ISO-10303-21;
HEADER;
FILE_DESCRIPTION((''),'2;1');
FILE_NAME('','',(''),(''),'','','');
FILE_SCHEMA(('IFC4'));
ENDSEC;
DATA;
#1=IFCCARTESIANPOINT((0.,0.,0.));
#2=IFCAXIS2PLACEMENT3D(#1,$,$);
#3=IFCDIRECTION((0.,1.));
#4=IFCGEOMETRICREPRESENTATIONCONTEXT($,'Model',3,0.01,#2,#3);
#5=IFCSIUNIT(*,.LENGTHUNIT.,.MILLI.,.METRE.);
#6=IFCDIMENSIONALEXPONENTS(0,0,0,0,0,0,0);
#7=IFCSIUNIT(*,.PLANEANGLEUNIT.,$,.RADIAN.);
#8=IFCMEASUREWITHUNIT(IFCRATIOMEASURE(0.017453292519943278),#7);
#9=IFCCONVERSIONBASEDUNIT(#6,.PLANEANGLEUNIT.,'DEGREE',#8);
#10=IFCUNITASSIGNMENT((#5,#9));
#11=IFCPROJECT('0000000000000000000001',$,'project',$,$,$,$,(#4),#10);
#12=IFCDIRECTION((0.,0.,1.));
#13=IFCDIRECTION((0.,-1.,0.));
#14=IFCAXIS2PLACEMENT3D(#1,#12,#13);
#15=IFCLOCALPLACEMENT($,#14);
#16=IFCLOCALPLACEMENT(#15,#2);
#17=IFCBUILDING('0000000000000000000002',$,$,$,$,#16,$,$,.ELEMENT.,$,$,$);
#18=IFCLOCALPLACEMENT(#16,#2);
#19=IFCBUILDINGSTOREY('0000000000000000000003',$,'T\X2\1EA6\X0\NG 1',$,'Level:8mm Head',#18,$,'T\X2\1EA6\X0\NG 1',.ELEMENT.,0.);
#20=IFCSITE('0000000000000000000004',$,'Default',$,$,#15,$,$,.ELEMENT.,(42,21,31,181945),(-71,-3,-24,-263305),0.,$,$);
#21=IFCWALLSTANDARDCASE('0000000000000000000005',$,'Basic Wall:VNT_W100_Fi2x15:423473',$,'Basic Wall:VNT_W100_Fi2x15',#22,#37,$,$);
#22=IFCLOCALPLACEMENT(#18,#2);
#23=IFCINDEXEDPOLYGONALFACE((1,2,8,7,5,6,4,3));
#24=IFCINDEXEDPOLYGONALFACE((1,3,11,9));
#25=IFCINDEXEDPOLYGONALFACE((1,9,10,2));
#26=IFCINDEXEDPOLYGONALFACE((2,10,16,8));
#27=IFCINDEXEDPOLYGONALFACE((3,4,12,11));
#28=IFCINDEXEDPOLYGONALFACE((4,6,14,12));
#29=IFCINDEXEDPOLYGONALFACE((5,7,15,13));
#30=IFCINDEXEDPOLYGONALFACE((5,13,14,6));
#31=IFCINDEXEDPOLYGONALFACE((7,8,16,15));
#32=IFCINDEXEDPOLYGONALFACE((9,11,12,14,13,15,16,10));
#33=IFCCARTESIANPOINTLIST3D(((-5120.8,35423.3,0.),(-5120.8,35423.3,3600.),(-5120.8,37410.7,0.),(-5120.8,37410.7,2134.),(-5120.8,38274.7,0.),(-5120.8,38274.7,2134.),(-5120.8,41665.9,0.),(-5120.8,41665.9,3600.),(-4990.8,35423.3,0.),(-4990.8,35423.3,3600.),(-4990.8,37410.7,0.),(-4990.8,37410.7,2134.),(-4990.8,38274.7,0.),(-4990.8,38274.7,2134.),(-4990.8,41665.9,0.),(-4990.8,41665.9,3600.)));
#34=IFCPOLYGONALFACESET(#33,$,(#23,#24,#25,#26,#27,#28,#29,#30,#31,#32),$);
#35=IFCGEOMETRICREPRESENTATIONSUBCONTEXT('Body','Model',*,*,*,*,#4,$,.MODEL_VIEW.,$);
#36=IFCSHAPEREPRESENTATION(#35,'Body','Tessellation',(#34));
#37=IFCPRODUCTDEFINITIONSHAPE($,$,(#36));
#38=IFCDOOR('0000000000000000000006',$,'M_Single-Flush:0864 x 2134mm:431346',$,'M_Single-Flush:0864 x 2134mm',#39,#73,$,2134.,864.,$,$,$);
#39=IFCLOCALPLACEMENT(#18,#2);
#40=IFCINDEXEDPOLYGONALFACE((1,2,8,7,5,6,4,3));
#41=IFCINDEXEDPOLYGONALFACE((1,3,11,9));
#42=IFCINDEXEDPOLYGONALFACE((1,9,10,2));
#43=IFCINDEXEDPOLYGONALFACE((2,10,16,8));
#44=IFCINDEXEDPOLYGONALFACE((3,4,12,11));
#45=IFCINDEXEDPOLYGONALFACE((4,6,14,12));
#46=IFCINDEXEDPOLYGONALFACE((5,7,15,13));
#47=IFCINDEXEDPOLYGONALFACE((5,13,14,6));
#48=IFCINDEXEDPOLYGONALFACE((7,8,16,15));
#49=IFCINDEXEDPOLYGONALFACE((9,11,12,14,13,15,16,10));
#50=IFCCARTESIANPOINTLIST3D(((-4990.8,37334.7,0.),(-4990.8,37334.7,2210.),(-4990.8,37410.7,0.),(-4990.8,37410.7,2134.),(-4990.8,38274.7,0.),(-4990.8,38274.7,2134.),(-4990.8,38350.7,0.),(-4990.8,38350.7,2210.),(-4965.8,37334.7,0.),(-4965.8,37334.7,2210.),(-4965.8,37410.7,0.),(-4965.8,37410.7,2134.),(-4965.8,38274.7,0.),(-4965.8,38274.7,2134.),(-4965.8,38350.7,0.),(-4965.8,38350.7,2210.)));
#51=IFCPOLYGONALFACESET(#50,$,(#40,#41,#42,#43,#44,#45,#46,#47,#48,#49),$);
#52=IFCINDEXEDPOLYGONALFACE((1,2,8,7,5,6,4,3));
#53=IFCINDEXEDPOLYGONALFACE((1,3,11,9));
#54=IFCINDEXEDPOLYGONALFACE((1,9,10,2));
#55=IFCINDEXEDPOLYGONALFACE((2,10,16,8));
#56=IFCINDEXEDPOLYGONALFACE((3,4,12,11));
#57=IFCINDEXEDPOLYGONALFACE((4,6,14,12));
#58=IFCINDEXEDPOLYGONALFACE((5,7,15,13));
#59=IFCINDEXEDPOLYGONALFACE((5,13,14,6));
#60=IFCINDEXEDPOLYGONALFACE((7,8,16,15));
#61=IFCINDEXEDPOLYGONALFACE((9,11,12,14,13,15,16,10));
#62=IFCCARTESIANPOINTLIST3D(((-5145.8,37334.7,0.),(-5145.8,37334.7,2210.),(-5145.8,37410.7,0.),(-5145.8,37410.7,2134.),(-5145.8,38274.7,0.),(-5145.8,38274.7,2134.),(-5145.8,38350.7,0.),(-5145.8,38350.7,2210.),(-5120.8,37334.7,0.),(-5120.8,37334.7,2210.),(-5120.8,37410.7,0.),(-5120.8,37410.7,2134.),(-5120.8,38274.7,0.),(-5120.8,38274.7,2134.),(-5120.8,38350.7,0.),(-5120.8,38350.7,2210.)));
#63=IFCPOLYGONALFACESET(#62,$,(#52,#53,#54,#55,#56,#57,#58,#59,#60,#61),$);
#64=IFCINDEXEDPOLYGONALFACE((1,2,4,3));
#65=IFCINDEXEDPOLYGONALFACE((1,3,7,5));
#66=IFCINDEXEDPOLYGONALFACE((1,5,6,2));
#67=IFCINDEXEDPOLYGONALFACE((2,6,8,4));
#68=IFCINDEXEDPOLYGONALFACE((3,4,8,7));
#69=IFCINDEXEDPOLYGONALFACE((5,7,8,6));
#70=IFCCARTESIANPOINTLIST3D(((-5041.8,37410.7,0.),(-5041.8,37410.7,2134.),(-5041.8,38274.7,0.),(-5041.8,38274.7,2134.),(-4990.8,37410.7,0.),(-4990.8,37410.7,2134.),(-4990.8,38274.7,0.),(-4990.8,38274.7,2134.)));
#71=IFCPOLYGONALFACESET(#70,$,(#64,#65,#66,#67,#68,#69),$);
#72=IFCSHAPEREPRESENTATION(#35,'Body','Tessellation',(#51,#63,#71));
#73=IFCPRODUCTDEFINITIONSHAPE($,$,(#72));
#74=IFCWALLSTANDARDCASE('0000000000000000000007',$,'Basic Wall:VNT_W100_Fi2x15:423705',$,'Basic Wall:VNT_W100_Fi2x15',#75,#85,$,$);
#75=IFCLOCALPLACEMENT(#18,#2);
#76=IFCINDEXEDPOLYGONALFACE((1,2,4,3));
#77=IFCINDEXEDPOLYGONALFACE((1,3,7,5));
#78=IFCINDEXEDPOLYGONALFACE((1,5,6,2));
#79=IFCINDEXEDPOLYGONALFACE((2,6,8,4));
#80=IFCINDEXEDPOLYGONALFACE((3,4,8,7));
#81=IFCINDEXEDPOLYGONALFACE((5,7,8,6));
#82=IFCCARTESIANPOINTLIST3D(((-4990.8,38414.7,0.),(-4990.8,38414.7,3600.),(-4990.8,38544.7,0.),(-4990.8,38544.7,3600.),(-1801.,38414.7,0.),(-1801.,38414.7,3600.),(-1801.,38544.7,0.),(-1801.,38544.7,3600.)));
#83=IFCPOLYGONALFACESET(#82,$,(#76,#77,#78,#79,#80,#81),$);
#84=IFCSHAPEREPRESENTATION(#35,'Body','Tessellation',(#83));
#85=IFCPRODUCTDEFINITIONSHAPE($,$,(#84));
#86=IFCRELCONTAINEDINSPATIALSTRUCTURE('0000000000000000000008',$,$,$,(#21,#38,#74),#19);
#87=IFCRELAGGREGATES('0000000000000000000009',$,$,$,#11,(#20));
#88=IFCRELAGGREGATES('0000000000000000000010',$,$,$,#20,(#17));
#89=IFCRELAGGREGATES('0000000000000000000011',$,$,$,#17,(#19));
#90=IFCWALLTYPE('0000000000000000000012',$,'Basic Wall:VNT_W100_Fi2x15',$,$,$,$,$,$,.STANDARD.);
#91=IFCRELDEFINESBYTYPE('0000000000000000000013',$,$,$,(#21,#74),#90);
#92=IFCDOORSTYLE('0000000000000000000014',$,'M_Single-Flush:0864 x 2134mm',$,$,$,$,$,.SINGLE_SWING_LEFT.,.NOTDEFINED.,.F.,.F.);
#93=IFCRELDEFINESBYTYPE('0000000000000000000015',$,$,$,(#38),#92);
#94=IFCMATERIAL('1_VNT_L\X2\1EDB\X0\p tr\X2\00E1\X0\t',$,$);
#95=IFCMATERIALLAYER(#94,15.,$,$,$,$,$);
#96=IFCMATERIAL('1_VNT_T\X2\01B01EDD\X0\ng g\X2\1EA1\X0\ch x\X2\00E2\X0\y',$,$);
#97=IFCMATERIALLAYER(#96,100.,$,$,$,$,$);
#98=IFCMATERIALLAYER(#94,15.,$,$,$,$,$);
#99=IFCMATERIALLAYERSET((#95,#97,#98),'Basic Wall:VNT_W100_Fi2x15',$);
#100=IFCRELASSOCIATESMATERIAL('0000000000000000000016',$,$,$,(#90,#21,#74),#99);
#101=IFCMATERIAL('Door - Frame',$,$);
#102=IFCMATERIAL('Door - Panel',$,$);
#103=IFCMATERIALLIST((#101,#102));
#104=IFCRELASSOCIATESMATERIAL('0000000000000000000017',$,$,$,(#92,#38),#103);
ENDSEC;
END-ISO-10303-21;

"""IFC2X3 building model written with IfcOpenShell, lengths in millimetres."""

from ifc_helpers import new_model, entity, si_unit, converted_unit, direction, frame, frame_2d, origin, place, context, subcontext, project, spatial, polyline, rectangle, outline, extrude, source, transform, mapped, material, material_list, layer, layer_set, layer_usage, type_object, type_shapes, element, fill, save


model = new_model("IFC2X3")

# Units and contexts
model_context = context("Model", 3, precision=0.01, world=origin(), true_north=direction((0.0, 1.0)))
body_context = subcontext(model_context, "Body", "Model", "MODEL_VIEW")
ifc_project = project(units=[si_unit("LENGTHUNIT", "METRE", prefix="MILLI"), converted_unit("PLANEANGLEUNIT", "DEGREE", entity("IfcRatioMeasure", 0.017453292519943278), si_unit("PLANEANGLEUNIT", "RADIAN"), dimensions=[0, 0, 0, 0, 0, 0, 0])], contexts=[model_context])

# Site, building, storey
site_placement = place(None, frame((0.0, 0.0, 0.0), z_axis=(0.0, 0.0, 1.0), x_axis=(0.0, -1.0, 0.0)))
site = spatial("IfcSite", under=ifc_project, at=site_placement, Name="Default", CompositionType="ELEMENT", RefLatitude=(42, 21, 31, 181945), RefLongitude=(-71, -3, -24, -263305), RefElevation=0.0)
building_placement = place(site_placement, origin())
building = spatial("IfcBuilding", under=site, at=building_placement, CompositionType="ELEMENT")
storey_placement = place(building_placement, origin())
storey = spatial("IfcBuildingStorey", under=building, at=storey_placement, Name="TẦNG 1", ObjectType="Level:8mm Head", LongName="TẦNG 1", CompositionType="ELEMENT", Elevation=0.0)

# Shared definitions
ifc_material_1 = material(Name="1_VNT_Lớp trát")
ifc_material_2 = material(Name="1_VNT_Tường gạch xây")

# Shared definitions
ifc_material_3 = material(Name="Door - Frame")
ifc_material_4 = material(Name="Door - Panel")
ifc_material_list = material_list([ifc_material_3, ifc_material_4])

# Wall, opening, door
ifc_layer_1 = layer(ifc_material_1, 15.0)
ifc_layer_2 = layer(ifc_material_2, 100.0)
ifc_layer_3 = layer(ifc_material_1, 15.0)
ifc_layer_set_1 = layer_set([ifc_layer_1, ifc_layer_2, ifc_layer_3], Name="Basic Wall:VNT_W100_Fi2x15")
ifc_layer_usage_1 = layer_usage(ifc_layer_set_1, "AXIS2", "NEGATIVE", 65.0)
wall_type_1 = type_object("IfcWallType", Name="Basic Wall:VNT_W100_Fi2x15", PredefinedType="STANDARD", material=ifc_layer_set_1)
wall_1_placement = place(storey_placement, frame((-5055.8, 35423.3, 0.0), z_axis=(0.0, 0.0, 1.0), x_axis=(0.0, 1.0, 0.0)))
wall_1 = element("IfcWallStandardCase", 1, at=wall_1_placement, inside=storey, type_object=wall_type_1, material=ifc_layer_usage_1, Name="Basic Wall:VNT_W100_Fi2x15:423473", ObjectType="Basic Wall:VNT_W100_Fi2x15", context=body_context, shape_type="SweptSolid", body=[
    extrude(rectangle(XDim=6242.6, YDim=130.0, at=frame_2d((3121.3, 0.0), x_axis=(-1.0, 0.0))), origin(), (0.0, 0.0, 1.0), 3600.0),
])
opening_1_placement = place(wall_1_placement, frame((2851.4, 65.0, 0.0)))
opening_1 = element("IfcOpeningElement", 2, at=opening_1_placement, cuts=wall_1, ObjectType="Opening", context=body_context, shape_type="SweptSolid", body=[
    extrude(rectangle(XDim=864.0, YDim=2134.0, at=frame_2d((1067.0, 432.0), x_axis=(0.0, -1.0))), frame((0.0, 0.0, 0.0), z_axis=(0.0, -1.0, 0.0), x_axis=(0.0, 0.0, 1.0)), (0.0, 0.0, 1.0), 130.0),
])
door_style_1 = type_object("IfcDoorStyle", Name="M_Single-Flush:0864 x 2134mm", ConstructionType="NOTDEFINED", OperationType="SINGLE_SWING_LEFT", ParameterTakesPrecedence=False, Sizeable=False, material=ifc_material_list)
shared_shape_1 = source(origin(), body_context, "Body", "SweptSolid", [
    extrude(outline(polyline([(-508.0, -1124.0), (508.0, -1124.0), (508.0, 1086.0), (432.0, 1086.0), (432.0, -1048.0), (-432.0, -1048.0), (-432.0, 1086.0), (-508.0, 1086.0), (-508.0, -1124.0)])), frame((432.0, 155.0, 1086.0), z_axis=(0.0, -1.0, 0.0), x_axis=(-1.0, 0.0, 0.0)), (0.0, 0.0, 1.0), 25.0),
    extrude(outline(polyline([(-1124.0, -508.0), (1086.0, -508.0), (1086.0, -432.0), (-1048.0, -432.0), (-1048.0, 432.0), (1086.0, 432.0), (1086.0, 508.0), (-1124.0, 508.0), (-1124.0, -508.0)])), frame((432.0, 0.0, 1086.0), z_axis=(0.0, -1.0, 0.0), x_axis=(0.0, 0.0, -1.0)), (0.0, 0.0, 1.0), 25.0),
    extrude(rectangle(XDim=864.0, YDim=51.0, at=frame_2d((0.0, 0.0), x_axis=(1.0, 0.0))), frame((432.0, 104.5, 0.0)), (0.0, 0.0, 1.0), 2134.0),
])
type_shapes(door_style_1, [shared_shape_1])
door_1_placement = place(opening_1_placement, frame((0.0, 0.0, 0.0), z_axis=(0.0, 0.0, 1.0), x_axis=(-1.0, 0.0, 0.0)))
door_1 = element("IfcDoor", 3, at=door_1_placement, inside=storey, type_object=door_style_1, material=ifc_material_list, Name="M_Single-Flush:0864 x 2134mm:431346", ObjectType="M_Single-Flush:0864 x 2134mm", OverallHeight=2134.0, OverallWidth=864.0, context=body_context, shape_type="MappedRepresentation", body=[
    mapped(shared_shape_1, transform((0.0, 0.0, 0.0), scale=1.0)),
])
fill(opening_1, door_1)

# Wall
wall_2_placement = place(storey_placement, frame((-4990.8, 38479.7, 0.0)))
element("IfcWallStandardCase", 4, at=wall_2_placement, inside=storey, type_object=wall_type_1, material=ifc_layer_usage_1, Name="Basic Wall:VNT_W100_Fi2x15:423705", ObjectType="Basic Wall:VNT_W100_Fi2x15", context=body_context, shape_type="SweptSolid", body=[
    extrude(rectangle(XDim=3189.8, YDim=130.0, at=frame_2d((1594.9, 0.0), x_axis=(-1.0, 0.0))), origin(), (0.0, 0.0, 1.0), 3600.0),
])

save(model, "model.ifc")
